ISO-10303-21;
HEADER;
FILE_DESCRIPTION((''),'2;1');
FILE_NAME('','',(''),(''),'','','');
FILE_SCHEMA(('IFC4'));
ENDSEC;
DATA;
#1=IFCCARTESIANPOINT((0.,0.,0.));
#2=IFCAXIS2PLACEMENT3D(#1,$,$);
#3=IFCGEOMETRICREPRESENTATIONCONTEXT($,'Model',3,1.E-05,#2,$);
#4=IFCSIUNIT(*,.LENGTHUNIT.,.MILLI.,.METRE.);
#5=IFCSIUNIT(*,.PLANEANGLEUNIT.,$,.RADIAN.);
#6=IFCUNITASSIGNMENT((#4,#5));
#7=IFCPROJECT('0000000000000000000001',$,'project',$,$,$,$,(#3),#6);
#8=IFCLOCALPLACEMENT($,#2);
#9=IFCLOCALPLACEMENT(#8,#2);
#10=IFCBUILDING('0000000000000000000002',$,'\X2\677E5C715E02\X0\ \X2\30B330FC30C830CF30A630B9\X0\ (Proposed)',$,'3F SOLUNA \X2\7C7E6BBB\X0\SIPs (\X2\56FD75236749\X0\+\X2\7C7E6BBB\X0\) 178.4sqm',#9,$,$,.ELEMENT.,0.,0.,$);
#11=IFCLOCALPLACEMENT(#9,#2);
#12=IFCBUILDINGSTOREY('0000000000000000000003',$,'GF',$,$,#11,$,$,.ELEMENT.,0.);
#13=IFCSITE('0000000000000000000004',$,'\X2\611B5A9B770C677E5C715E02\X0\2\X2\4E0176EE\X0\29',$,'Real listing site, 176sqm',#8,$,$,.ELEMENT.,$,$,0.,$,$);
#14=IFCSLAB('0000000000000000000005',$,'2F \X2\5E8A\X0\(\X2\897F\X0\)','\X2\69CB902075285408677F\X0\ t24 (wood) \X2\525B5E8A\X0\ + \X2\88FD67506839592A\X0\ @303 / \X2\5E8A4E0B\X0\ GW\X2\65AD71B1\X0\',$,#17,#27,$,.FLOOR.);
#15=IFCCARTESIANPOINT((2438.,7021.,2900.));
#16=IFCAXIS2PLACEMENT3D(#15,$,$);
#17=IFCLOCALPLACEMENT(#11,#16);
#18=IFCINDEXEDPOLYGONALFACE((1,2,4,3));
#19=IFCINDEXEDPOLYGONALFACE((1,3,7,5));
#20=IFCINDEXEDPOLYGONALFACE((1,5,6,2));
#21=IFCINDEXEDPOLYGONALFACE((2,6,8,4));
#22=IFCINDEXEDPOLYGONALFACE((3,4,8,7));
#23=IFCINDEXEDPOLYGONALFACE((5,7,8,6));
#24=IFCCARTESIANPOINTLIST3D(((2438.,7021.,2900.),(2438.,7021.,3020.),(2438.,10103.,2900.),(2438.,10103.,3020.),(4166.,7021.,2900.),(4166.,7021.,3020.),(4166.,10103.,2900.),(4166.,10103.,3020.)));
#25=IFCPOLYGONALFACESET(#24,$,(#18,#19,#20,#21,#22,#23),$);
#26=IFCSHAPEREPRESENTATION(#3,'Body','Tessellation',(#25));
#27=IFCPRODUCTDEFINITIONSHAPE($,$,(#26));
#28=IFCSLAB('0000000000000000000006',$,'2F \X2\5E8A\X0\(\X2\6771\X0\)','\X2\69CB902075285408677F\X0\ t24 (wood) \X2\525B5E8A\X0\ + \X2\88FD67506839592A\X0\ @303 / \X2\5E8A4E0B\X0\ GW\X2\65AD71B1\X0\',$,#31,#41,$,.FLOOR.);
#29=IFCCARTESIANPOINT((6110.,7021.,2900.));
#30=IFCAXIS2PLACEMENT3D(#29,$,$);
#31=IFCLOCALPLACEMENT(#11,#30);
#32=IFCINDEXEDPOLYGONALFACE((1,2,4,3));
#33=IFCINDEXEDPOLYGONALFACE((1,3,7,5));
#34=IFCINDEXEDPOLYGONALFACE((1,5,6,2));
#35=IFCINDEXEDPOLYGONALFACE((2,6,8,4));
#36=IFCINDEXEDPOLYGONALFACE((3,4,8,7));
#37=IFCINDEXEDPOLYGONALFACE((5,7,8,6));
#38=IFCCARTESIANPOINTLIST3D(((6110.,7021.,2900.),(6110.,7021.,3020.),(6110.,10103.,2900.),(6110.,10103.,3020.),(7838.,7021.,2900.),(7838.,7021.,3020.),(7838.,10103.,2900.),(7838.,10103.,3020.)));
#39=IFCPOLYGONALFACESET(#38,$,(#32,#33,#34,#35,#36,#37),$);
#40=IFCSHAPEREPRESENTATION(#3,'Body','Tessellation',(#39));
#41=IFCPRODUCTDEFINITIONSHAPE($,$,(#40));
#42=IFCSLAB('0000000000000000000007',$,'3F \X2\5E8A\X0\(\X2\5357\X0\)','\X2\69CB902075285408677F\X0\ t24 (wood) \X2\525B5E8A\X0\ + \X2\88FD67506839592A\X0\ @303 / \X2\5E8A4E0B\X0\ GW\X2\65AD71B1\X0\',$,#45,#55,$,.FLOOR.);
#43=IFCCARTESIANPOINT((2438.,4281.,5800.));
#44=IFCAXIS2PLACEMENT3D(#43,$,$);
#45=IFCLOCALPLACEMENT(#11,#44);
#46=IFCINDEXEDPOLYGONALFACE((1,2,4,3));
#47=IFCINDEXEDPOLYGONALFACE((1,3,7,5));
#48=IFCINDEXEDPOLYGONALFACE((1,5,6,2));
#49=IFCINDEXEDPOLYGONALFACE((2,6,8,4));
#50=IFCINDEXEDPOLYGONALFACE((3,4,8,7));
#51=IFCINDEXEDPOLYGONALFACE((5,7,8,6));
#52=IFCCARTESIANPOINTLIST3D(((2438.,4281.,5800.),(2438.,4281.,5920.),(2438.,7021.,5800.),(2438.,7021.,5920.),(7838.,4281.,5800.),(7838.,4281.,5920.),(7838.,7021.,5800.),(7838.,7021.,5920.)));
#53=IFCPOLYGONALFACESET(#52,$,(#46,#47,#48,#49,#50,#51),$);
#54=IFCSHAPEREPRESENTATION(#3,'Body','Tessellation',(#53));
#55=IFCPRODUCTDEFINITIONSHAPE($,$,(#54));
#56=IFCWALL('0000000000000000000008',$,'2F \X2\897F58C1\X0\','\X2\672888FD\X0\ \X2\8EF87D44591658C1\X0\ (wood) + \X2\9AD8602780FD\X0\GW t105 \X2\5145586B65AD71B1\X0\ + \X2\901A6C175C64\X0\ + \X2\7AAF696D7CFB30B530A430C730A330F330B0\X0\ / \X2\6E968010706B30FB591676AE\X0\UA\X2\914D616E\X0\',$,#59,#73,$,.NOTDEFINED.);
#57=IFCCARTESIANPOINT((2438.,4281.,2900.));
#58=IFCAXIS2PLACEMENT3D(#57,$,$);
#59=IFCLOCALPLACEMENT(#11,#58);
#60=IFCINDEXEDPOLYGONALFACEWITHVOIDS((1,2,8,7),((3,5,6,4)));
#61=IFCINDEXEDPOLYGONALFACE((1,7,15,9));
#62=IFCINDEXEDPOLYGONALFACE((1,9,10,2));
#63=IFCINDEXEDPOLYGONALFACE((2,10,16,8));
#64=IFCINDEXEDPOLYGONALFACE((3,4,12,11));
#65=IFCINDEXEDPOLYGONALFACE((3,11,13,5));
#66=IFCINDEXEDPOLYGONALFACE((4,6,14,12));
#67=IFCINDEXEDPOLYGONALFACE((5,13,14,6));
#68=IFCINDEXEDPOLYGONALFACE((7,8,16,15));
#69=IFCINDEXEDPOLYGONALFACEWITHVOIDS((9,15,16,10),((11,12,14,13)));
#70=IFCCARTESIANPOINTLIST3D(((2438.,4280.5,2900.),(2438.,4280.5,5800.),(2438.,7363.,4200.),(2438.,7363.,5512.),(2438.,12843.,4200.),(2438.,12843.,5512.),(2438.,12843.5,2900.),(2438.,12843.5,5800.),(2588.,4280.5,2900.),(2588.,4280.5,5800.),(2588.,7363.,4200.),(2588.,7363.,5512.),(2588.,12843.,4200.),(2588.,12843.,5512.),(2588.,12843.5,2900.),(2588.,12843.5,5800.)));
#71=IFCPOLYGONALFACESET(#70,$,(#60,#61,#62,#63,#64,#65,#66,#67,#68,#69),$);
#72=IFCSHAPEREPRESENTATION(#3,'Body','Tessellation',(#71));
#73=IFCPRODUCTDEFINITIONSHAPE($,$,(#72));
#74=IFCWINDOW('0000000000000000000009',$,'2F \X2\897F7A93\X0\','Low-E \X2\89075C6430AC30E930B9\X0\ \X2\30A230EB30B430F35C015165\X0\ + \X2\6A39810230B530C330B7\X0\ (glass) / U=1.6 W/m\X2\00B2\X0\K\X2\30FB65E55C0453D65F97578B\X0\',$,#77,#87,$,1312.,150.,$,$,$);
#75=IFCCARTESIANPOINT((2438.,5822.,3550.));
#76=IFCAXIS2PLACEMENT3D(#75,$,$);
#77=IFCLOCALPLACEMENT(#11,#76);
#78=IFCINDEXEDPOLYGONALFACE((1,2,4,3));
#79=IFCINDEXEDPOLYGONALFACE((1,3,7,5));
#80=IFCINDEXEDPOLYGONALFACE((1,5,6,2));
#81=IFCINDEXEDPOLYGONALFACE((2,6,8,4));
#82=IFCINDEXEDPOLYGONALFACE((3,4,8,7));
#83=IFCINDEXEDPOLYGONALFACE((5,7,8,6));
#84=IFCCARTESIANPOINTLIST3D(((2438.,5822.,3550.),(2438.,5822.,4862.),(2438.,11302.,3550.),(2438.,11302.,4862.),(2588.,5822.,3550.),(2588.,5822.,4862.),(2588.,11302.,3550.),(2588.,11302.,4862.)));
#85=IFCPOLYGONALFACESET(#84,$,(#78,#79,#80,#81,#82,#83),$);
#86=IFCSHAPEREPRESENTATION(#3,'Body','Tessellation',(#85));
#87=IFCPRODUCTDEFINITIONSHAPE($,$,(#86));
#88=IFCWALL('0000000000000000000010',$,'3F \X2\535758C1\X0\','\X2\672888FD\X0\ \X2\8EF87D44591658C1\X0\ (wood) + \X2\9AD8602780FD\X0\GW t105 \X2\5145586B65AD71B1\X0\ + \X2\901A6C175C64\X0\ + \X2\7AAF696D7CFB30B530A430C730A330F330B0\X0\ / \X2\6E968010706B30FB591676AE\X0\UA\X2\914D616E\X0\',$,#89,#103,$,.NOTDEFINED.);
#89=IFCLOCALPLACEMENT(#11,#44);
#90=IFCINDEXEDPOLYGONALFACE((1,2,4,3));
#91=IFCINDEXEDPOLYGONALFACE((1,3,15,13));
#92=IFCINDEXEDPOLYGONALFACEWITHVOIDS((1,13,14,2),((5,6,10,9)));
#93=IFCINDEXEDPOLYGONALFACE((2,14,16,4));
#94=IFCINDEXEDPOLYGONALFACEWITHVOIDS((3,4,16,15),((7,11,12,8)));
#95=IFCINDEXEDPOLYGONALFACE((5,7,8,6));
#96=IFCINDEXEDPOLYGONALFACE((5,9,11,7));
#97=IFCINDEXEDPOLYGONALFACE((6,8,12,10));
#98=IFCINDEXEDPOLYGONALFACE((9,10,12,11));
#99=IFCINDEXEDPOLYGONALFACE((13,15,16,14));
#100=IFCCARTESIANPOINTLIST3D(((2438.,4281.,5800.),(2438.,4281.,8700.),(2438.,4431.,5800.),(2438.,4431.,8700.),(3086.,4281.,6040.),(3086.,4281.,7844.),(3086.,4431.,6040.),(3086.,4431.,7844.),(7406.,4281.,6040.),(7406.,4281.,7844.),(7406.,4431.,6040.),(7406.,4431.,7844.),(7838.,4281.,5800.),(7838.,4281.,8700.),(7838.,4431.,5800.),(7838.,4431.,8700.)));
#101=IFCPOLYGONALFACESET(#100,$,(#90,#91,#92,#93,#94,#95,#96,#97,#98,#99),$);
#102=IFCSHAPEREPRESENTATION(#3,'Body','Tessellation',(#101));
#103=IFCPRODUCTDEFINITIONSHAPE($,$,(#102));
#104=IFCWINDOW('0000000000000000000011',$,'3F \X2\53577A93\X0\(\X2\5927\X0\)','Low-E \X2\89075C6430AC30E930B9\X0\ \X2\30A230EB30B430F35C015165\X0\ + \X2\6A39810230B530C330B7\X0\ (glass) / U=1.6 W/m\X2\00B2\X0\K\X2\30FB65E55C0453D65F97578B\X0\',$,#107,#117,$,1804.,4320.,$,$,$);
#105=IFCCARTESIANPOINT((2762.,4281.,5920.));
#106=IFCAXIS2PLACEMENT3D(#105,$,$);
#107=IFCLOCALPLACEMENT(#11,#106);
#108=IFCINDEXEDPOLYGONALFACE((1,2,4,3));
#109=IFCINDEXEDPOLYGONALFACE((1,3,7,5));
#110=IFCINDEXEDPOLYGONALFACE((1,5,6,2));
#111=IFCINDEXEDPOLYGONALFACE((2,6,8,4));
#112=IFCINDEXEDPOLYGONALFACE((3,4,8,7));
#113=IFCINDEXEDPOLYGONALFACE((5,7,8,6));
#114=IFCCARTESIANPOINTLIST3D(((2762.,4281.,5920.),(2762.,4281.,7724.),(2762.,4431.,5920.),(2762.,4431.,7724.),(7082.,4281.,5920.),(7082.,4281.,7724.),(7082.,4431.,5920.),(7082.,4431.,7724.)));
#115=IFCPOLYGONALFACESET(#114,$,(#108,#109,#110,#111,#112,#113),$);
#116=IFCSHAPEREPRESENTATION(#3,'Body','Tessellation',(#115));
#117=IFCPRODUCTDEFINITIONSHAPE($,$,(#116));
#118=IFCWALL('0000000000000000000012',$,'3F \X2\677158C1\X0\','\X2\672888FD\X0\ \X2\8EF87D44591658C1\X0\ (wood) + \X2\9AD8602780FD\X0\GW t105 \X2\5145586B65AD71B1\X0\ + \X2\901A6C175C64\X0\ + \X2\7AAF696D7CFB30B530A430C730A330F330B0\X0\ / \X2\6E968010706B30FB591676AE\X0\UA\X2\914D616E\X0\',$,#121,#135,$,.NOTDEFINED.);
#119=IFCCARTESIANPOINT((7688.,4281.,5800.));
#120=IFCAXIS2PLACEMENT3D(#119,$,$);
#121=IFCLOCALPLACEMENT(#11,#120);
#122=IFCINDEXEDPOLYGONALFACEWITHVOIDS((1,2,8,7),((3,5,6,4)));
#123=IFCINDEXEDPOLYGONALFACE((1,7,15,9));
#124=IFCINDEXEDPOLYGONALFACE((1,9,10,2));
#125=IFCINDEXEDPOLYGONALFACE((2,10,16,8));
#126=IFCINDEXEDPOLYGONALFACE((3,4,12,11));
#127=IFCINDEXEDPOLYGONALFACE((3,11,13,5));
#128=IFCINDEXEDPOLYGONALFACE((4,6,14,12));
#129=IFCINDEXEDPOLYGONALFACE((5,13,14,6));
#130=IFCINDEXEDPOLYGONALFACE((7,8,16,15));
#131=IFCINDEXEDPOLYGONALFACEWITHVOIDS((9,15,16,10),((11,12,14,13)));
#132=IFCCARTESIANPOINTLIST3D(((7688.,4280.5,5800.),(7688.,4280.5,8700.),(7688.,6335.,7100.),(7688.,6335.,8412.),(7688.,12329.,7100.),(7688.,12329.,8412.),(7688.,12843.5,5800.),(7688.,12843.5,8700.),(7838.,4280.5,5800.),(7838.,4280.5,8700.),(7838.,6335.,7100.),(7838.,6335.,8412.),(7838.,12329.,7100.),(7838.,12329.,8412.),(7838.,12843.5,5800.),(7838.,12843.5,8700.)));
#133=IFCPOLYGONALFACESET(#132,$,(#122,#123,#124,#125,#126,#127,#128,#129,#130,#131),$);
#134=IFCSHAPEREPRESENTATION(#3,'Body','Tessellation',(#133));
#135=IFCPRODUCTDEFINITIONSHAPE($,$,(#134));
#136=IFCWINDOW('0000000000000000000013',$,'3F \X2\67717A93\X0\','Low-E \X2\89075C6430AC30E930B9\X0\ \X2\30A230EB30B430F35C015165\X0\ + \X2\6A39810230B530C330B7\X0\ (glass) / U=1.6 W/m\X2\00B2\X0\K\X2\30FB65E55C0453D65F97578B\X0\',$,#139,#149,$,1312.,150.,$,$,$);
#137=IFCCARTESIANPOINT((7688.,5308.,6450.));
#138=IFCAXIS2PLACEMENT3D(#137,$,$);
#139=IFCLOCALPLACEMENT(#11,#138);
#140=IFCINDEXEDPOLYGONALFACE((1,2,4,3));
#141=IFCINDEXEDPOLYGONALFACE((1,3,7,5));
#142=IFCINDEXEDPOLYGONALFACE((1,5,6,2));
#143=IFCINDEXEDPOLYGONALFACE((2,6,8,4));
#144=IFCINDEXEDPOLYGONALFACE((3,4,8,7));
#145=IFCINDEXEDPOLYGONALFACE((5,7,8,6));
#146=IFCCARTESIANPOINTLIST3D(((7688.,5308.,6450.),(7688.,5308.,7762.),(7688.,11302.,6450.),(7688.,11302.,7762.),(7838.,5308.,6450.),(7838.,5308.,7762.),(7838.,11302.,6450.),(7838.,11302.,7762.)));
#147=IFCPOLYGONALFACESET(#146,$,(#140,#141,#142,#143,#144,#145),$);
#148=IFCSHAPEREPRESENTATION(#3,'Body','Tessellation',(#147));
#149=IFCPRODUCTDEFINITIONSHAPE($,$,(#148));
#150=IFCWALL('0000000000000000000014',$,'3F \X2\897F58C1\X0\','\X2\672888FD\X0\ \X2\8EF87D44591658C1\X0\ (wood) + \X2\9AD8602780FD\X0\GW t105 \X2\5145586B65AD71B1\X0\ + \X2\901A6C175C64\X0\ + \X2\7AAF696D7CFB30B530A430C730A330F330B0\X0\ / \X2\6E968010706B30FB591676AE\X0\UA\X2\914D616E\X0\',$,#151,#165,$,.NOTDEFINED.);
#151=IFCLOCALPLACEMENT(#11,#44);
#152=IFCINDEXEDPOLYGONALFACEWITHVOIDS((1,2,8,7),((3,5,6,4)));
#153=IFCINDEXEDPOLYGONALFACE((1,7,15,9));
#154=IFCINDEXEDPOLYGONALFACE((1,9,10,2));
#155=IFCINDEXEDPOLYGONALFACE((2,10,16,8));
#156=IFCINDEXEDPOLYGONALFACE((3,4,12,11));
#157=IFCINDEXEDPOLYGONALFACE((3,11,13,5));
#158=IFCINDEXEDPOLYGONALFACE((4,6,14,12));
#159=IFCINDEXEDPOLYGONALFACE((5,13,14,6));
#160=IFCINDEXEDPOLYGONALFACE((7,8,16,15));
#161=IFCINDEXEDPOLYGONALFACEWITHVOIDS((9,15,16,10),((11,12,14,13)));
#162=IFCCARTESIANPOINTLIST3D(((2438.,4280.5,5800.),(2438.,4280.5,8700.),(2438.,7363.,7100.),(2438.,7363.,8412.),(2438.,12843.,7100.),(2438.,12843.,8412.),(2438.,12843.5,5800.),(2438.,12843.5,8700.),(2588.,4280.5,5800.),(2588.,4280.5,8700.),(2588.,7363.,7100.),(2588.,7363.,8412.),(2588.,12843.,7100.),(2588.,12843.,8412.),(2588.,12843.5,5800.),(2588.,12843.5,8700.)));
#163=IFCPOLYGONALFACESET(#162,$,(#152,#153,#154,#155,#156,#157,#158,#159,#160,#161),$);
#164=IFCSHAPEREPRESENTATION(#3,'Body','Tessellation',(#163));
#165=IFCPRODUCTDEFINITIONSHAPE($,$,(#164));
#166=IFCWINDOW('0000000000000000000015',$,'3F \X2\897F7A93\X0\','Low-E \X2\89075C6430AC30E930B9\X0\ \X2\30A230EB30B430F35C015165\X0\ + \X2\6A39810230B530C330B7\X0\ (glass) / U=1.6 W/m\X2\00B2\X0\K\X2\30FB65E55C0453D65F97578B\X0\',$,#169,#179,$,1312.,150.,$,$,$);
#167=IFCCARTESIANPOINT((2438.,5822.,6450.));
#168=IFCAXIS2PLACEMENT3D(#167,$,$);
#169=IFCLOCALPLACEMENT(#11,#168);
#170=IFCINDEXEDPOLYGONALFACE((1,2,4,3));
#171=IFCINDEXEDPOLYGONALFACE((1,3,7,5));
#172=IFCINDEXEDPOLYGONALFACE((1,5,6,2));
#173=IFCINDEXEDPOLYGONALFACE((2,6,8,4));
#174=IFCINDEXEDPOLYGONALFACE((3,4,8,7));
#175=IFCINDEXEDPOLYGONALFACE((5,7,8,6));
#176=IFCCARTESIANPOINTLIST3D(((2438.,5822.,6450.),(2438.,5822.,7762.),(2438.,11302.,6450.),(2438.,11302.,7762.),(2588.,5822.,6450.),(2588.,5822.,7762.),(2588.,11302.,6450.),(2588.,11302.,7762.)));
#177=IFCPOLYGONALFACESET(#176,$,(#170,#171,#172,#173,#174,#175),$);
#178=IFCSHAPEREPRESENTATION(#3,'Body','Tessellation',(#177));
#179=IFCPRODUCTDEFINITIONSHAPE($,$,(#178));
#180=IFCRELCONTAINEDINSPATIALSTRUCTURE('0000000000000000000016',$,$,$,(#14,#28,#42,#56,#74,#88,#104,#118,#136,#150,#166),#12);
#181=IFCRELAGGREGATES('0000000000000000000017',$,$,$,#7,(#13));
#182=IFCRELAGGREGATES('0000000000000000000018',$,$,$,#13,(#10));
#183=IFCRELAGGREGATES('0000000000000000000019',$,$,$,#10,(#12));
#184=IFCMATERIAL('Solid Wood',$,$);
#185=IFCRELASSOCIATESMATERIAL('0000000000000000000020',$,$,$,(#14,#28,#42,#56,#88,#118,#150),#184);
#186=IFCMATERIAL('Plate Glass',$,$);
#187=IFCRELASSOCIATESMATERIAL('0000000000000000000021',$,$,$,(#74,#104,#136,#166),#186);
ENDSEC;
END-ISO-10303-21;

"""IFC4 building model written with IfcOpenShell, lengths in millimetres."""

from ifc_helpers import new_model, si_unit, frame, frame_2d, origin, place, context, project, spatial, rectangle, extrude, material, element, fill, save


model = new_model("IFC4")

# Units and contexts
model_context = context("Model", 3, precision=1e-05, world=origin())
ifc_project = project(units=[si_unit("LENGTHUNIT", "METRE", prefix="MILLI"), si_unit("PLANEANGLEUNIT", "RADIAN")], contexts=[model_context])

# Site, building, storey
site_placement = place(None, origin())
site = spatial("IfcSite", under=ifc_project, at=site_placement, Name="愛媛県松山市2丁目29", ObjectType="Real listing site, 176sqm", CompositionType="ELEMENT", RefElevation=0.0)
building_placement = place(site_placement, origin())
building = spatial("IfcBuilding", under=site, at=building_placement, Name="松山市 コートハウス (Proposed)", ObjectType="3F SOLUNA 籾殻SIPs (国産杉+籾殻) 178.4sqm", CompositionType="ELEMENT", ElevationOfRefHeight=0.0, ElevationOfTerrain=0.0)
storey_placement = place(building_placement, origin())
storey = spatial("IfcBuildingStorey", under=building, at=storey_placement, Name="GF", CompositionType="ELEMENT", Elevation=0.0)

# Slabs
ifc_material_1 = material(Name="Solid Wood")
slab_1_placement = place(storey_placement, frame((2438.0, 7021.0, 2900.0)))
element("IfcSlab", 1, at=slab_1_placement, inside=storey, material=ifc_material_1, Name="2F 床(西)", Description="構造用合板 t24 (wood) 剛床 + 製材根太 @303 / 床下 GW断熱", PredefinedType="FLOOR", context=model_context, shape_type="SweptSolid", body=[
    extrude(rectangle(XDim=1728.0, YDim=3082.0, at=frame_2d((864.0, 1541.0))), frame((2438.0, 7021.0, 2900.0)), (0.0, 0.0, 1.0), 120.0),
])
slab_2_placement = place(storey_placement, frame((6110.0, 7021.0, 2900.0)))
element("IfcSlab", 2, at=slab_2_placement, inside=storey, material=ifc_material_1, Name="2F 床(東)", Description="構造用合板 t24 (wood) 剛床 + 製材根太 @303 / 床下 GW断熱", PredefinedType="FLOOR", context=model_context, shape_type="SweptSolid", body=[
    extrude(rectangle(XDim=1728.0, YDim=3082.0, at=frame_2d((864.0, 1541.0))), frame((6110.0, 7021.0, 2900.0)), (0.0, 0.0, 1.0), 120.0),
])
slab_3_placement = place(storey_placement, frame((2438.0, 4281.0, 5800.0)))
element("IfcSlab", 3, at=slab_3_placement, inside=storey, material=ifc_material_1, Name="3F 床(南)", Description="構造用合板 t24 (wood) 剛床 + 製材根太 @303 / 床下 GW断熱", PredefinedType="FLOOR", context=model_context, shape_type="SweptSolid", body=[
    extrude(rectangle(XDim=5400.0, YDim=2740.0, at=frame_2d((2700.0, 1370.0))), frame((2438.0, 4281.0, 5800.0)), (0.0, 0.0, 1.0), 120.0),
])

# Walls, openings, windows
wall_1_placement = place(storey_placement, frame((2438.0, 4281.0, 2900.0)))
wall_1 = element("IfcWall", 4, at=wall_1_placement, inside=storey, material=ifc_material_1, Name="2F 西壁", Description="木製 軸組外壁 (wood) + 高性能GW t105 充填断熱 + 通気層 + 窯業系サイディング / 準耐火・外皮UA配慮", PredefinedType="NOTDEFINED", context=model_context, shape_type="SweptSolid", body=[
    extrude(rectangle(XDim=150.0, YDim=8563.0, at=frame_2d((75.0, 4281.0))), frame((2438.0, 4281.0, 2900.0)), (0.0, 0.0, 1.0), 2900.0),
])
opening_1_placement = place(storey_placement, frame((2438.0, 5822.0, 3550.0)))
opening_1 = element("IfcOpeningElement", 5, at=opening_1_placement, cuts=wall_1, PredefinedType="NOTDEFINED", context=model_context, shape_type="SweptSolid", body=[
    extrude(rectangle(XDim=150.0, YDim=5480.0, at=frame_2d((75.0, 2740.0))), frame((2438.0, 5822.0, 3550.0)), (0.0, 0.0, 1.0), 1312.0),
])
ifc_material_2 = material(Name="Plate Glass")
window_1_placement = place(storey_placement, frame((2438.0, 5822.0, 3550.0)))
window_1 = element("IfcWindow", 6, at=window_1_placement, inside=storey, material=ifc_material_2, Name="2F 西窓", Description="Low-E 複層ガラス アルゴン封入 + 樹脂サッシ (glass) / U=1.6 W/m²K・日射取得型", OverallHeight=1312.0, OverallWidth=150.0, context=model_context, shape_type="SweptSolid", body=[
    extrude(rectangle(XDim=150.0, YDim=5480.0, at=frame_2d((75.0, 2740.0))), frame((2438.0, 5822.0, 3550.0)), (0.0, 0.0, 1.0), 1312.0),
])
fill(opening_1, window_1)
wall_2_placement = place(storey_placement, frame((2438.0, 4281.0, 5800.0)))
wall_2 = element("IfcWall", 7, at=wall_2_placement, inside=storey, material=ifc_material_1, Name="3F 南壁", Description="木製 軸組外壁 (wood) + 高性能GW t105 充填断熱 + 通気層 + 窯業系サイディング / 準耐火・外皮UA配慮", PredefinedType="NOTDEFINED", context=model_context, shape_type="SweptSolid", body=[
    extrude(rectangle(XDim=5400.0, YDim=150.0, at=frame_2d((2700.0, 75.0))), frame((2438.0, 4281.0, 5800.0)), (0.0, 0.0, 1.0), 2900.0),
])
opening_2_placement = place(storey_placement, frame((2762.0, 4281.0, 5920.0)))
opening_2 = element("IfcOpeningElement", 8, at=opening_2_placement, cuts=wall_2, PredefinedType="NOTDEFINED", context=model_context, shape_type="SweptSolid", body=[
    extrude(rectangle(XDim=4320.0, YDim=150.0, at=frame_2d((2160.0, 75.0))), frame((2762.0, 4281.0, 5920.0)), (0.0, 0.0, 1.0), 1804.0),
])
window_2_placement = place(storey_placement, frame((2762.0, 4281.0, 5920.0)))
window_2 = element("IfcWindow", 9, at=window_2_placement, inside=storey, material=ifc_material_2, Name="3F 南窓(大)", Description="Low-E 複層ガラス アルゴン封入 + 樹脂サッシ (glass) / U=1.6 W/m²K・日射取得型", OverallHeight=1804.0, OverallWidth=4320.0, context=model_context, shape_type="SweptSolid", body=[
    extrude(rectangle(XDim=4320.0, YDim=150.0, at=frame_2d((2160.0, 75.0))), frame((2762.0, 4281.0, 5920.0)), (0.0, 0.0, 1.0), 1804.0),
])
fill(opening_2, window_2)
wall_3_placement = place(storey_placement, frame((7688.0, 4281.0, 5800.0)))
wall_3 = element("IfcWall", 10, at=wall_3_placement, inside=storey, material=ifc_material_1, Name="3F 東壁", Description="木製 軸組外壁 (wood) + 高性能GW t105 充填断熱 + 通気層 + 窯業系サイディング / 準耐火・外皮UA配慮", PredefinedType="NOTDEFINED", context=model_context, shape_type="SweptSolid", body=[
    extrude(rectangle(XDim=150.0, YDim=8563.0, at=frame_2d((75.0, 4281.0))), frame((7688.0, 4281.0, 5800.0)), (0.0, 0.0, 1.0), 2900.0),
])
opening_3_placement = place(storey_placement, frame((7688.0, 5308.0, 6450.0)))
opening_3 = element("IfcOpeningElement", 11, at=opening_3_placement, cuts=wall_3, PredefinedType="NOTDEFINED", context=model_context, shape_type="SweptSolid", body=[
    extrude(rectangle(XDim=150.0, YDim=5994.0, at=frame_2d((75.0, 2997.0))), frame((7688.0, 5308.0, 6450.0)), (0.0, 0.0, 1.0), 1312.0),
])
window_3_placement = place(storey_placement, frame((7688.0, 5308.0, 6450.0)))
window_3 = element("IfcWindow", 12, at=window_3_placement, inside=storey, material=ifc_material_2, Name="3F 東窓", Description="Low-E 複層ガラス アルゴン封入 + 樹脂サッシ (glass) / U=1.6 W/m²K・日射取得型", OverallHeight=1312.0, OverallWidth=150.0, context=model_context, shape_type="SweptSolid", body=[
    extrude(rectangle(XDim=150.0, YDim=5994.0, at=frame_2d((75.0, 2997.0))), frame((7688.0, 5308.0, 6450.0)), (0.0, 0.0, 1.0), 1312.0),
])
fill(opening_3, window_3)
wall_4_placement = place(storey_placement, frame((2438.0, 4281.0, 5800.0)))
wall_4 = element("IfcWall", 13, at=wall_4_placement, inside=storey, material=ifc_material_1, Name="3F 西壁", Description="木製 軸組外壁 (wood) + 高性能GW t105 充填断熱 + 通気層 + 窯業系サイディング / 準耐火・外皮UA配慮", PredefinedType="NOTDEFINED", context=model_context, shape_type="SweptSolid", body=[
    extrude(rectangle(XDim=150.0, YDim=8563.0, at=frame_2d((75.0, 4281.0))), frame((2438.0, 4281.0, 5800.0)), (0.0, 0.0, 1.0), 2900.0),
])
opening_4_placement = place(storey_placement, frame((2438.0, 5822.0, 6450.0)))
opening_4 = element("IfcOpeningElement", 14, at=opening_4_placement, cuts=wall_4, PredefinedType="NOTDEFINED", context=model_context, shape_type="SweptSolid", body=[
    extrude(rectangle(XDim=150.0, YDim=5480.0, at=frame_2d((75.0, 2740.0))), frame((2438.0, 5822.0, 6450.0)), (0.0, 0.0, 1.0), 1312.0),
])
window_4_placement = place(storey_placement, frame((2438.0, 5822.0, 6450.0)))
window_4 = element("IfcWindow", 15, at=window_4_placement, inside=storey, material=ifc_material_2, Name="3F 西窓", Description="Low-E 複層ガラス アルゴン封入 + 樹脂サッシ (glass) / U=1.6 W/m²K・日射取得型", OverallHeight=1312.0, OverallWidth=150.0, context=model_context, shape_type="SweptSolid", body=[
    extrude(rectangle(XDim=150.0, YDim=5480.0, at=frame_2d((75.0, 2740.0))), frame((2438.0, 5822.0, 6450.0)), (0.0, 0.0, 1.0), 1312.0),
])
fill(opening_4, window_4)

save(model, "model.ifc")
